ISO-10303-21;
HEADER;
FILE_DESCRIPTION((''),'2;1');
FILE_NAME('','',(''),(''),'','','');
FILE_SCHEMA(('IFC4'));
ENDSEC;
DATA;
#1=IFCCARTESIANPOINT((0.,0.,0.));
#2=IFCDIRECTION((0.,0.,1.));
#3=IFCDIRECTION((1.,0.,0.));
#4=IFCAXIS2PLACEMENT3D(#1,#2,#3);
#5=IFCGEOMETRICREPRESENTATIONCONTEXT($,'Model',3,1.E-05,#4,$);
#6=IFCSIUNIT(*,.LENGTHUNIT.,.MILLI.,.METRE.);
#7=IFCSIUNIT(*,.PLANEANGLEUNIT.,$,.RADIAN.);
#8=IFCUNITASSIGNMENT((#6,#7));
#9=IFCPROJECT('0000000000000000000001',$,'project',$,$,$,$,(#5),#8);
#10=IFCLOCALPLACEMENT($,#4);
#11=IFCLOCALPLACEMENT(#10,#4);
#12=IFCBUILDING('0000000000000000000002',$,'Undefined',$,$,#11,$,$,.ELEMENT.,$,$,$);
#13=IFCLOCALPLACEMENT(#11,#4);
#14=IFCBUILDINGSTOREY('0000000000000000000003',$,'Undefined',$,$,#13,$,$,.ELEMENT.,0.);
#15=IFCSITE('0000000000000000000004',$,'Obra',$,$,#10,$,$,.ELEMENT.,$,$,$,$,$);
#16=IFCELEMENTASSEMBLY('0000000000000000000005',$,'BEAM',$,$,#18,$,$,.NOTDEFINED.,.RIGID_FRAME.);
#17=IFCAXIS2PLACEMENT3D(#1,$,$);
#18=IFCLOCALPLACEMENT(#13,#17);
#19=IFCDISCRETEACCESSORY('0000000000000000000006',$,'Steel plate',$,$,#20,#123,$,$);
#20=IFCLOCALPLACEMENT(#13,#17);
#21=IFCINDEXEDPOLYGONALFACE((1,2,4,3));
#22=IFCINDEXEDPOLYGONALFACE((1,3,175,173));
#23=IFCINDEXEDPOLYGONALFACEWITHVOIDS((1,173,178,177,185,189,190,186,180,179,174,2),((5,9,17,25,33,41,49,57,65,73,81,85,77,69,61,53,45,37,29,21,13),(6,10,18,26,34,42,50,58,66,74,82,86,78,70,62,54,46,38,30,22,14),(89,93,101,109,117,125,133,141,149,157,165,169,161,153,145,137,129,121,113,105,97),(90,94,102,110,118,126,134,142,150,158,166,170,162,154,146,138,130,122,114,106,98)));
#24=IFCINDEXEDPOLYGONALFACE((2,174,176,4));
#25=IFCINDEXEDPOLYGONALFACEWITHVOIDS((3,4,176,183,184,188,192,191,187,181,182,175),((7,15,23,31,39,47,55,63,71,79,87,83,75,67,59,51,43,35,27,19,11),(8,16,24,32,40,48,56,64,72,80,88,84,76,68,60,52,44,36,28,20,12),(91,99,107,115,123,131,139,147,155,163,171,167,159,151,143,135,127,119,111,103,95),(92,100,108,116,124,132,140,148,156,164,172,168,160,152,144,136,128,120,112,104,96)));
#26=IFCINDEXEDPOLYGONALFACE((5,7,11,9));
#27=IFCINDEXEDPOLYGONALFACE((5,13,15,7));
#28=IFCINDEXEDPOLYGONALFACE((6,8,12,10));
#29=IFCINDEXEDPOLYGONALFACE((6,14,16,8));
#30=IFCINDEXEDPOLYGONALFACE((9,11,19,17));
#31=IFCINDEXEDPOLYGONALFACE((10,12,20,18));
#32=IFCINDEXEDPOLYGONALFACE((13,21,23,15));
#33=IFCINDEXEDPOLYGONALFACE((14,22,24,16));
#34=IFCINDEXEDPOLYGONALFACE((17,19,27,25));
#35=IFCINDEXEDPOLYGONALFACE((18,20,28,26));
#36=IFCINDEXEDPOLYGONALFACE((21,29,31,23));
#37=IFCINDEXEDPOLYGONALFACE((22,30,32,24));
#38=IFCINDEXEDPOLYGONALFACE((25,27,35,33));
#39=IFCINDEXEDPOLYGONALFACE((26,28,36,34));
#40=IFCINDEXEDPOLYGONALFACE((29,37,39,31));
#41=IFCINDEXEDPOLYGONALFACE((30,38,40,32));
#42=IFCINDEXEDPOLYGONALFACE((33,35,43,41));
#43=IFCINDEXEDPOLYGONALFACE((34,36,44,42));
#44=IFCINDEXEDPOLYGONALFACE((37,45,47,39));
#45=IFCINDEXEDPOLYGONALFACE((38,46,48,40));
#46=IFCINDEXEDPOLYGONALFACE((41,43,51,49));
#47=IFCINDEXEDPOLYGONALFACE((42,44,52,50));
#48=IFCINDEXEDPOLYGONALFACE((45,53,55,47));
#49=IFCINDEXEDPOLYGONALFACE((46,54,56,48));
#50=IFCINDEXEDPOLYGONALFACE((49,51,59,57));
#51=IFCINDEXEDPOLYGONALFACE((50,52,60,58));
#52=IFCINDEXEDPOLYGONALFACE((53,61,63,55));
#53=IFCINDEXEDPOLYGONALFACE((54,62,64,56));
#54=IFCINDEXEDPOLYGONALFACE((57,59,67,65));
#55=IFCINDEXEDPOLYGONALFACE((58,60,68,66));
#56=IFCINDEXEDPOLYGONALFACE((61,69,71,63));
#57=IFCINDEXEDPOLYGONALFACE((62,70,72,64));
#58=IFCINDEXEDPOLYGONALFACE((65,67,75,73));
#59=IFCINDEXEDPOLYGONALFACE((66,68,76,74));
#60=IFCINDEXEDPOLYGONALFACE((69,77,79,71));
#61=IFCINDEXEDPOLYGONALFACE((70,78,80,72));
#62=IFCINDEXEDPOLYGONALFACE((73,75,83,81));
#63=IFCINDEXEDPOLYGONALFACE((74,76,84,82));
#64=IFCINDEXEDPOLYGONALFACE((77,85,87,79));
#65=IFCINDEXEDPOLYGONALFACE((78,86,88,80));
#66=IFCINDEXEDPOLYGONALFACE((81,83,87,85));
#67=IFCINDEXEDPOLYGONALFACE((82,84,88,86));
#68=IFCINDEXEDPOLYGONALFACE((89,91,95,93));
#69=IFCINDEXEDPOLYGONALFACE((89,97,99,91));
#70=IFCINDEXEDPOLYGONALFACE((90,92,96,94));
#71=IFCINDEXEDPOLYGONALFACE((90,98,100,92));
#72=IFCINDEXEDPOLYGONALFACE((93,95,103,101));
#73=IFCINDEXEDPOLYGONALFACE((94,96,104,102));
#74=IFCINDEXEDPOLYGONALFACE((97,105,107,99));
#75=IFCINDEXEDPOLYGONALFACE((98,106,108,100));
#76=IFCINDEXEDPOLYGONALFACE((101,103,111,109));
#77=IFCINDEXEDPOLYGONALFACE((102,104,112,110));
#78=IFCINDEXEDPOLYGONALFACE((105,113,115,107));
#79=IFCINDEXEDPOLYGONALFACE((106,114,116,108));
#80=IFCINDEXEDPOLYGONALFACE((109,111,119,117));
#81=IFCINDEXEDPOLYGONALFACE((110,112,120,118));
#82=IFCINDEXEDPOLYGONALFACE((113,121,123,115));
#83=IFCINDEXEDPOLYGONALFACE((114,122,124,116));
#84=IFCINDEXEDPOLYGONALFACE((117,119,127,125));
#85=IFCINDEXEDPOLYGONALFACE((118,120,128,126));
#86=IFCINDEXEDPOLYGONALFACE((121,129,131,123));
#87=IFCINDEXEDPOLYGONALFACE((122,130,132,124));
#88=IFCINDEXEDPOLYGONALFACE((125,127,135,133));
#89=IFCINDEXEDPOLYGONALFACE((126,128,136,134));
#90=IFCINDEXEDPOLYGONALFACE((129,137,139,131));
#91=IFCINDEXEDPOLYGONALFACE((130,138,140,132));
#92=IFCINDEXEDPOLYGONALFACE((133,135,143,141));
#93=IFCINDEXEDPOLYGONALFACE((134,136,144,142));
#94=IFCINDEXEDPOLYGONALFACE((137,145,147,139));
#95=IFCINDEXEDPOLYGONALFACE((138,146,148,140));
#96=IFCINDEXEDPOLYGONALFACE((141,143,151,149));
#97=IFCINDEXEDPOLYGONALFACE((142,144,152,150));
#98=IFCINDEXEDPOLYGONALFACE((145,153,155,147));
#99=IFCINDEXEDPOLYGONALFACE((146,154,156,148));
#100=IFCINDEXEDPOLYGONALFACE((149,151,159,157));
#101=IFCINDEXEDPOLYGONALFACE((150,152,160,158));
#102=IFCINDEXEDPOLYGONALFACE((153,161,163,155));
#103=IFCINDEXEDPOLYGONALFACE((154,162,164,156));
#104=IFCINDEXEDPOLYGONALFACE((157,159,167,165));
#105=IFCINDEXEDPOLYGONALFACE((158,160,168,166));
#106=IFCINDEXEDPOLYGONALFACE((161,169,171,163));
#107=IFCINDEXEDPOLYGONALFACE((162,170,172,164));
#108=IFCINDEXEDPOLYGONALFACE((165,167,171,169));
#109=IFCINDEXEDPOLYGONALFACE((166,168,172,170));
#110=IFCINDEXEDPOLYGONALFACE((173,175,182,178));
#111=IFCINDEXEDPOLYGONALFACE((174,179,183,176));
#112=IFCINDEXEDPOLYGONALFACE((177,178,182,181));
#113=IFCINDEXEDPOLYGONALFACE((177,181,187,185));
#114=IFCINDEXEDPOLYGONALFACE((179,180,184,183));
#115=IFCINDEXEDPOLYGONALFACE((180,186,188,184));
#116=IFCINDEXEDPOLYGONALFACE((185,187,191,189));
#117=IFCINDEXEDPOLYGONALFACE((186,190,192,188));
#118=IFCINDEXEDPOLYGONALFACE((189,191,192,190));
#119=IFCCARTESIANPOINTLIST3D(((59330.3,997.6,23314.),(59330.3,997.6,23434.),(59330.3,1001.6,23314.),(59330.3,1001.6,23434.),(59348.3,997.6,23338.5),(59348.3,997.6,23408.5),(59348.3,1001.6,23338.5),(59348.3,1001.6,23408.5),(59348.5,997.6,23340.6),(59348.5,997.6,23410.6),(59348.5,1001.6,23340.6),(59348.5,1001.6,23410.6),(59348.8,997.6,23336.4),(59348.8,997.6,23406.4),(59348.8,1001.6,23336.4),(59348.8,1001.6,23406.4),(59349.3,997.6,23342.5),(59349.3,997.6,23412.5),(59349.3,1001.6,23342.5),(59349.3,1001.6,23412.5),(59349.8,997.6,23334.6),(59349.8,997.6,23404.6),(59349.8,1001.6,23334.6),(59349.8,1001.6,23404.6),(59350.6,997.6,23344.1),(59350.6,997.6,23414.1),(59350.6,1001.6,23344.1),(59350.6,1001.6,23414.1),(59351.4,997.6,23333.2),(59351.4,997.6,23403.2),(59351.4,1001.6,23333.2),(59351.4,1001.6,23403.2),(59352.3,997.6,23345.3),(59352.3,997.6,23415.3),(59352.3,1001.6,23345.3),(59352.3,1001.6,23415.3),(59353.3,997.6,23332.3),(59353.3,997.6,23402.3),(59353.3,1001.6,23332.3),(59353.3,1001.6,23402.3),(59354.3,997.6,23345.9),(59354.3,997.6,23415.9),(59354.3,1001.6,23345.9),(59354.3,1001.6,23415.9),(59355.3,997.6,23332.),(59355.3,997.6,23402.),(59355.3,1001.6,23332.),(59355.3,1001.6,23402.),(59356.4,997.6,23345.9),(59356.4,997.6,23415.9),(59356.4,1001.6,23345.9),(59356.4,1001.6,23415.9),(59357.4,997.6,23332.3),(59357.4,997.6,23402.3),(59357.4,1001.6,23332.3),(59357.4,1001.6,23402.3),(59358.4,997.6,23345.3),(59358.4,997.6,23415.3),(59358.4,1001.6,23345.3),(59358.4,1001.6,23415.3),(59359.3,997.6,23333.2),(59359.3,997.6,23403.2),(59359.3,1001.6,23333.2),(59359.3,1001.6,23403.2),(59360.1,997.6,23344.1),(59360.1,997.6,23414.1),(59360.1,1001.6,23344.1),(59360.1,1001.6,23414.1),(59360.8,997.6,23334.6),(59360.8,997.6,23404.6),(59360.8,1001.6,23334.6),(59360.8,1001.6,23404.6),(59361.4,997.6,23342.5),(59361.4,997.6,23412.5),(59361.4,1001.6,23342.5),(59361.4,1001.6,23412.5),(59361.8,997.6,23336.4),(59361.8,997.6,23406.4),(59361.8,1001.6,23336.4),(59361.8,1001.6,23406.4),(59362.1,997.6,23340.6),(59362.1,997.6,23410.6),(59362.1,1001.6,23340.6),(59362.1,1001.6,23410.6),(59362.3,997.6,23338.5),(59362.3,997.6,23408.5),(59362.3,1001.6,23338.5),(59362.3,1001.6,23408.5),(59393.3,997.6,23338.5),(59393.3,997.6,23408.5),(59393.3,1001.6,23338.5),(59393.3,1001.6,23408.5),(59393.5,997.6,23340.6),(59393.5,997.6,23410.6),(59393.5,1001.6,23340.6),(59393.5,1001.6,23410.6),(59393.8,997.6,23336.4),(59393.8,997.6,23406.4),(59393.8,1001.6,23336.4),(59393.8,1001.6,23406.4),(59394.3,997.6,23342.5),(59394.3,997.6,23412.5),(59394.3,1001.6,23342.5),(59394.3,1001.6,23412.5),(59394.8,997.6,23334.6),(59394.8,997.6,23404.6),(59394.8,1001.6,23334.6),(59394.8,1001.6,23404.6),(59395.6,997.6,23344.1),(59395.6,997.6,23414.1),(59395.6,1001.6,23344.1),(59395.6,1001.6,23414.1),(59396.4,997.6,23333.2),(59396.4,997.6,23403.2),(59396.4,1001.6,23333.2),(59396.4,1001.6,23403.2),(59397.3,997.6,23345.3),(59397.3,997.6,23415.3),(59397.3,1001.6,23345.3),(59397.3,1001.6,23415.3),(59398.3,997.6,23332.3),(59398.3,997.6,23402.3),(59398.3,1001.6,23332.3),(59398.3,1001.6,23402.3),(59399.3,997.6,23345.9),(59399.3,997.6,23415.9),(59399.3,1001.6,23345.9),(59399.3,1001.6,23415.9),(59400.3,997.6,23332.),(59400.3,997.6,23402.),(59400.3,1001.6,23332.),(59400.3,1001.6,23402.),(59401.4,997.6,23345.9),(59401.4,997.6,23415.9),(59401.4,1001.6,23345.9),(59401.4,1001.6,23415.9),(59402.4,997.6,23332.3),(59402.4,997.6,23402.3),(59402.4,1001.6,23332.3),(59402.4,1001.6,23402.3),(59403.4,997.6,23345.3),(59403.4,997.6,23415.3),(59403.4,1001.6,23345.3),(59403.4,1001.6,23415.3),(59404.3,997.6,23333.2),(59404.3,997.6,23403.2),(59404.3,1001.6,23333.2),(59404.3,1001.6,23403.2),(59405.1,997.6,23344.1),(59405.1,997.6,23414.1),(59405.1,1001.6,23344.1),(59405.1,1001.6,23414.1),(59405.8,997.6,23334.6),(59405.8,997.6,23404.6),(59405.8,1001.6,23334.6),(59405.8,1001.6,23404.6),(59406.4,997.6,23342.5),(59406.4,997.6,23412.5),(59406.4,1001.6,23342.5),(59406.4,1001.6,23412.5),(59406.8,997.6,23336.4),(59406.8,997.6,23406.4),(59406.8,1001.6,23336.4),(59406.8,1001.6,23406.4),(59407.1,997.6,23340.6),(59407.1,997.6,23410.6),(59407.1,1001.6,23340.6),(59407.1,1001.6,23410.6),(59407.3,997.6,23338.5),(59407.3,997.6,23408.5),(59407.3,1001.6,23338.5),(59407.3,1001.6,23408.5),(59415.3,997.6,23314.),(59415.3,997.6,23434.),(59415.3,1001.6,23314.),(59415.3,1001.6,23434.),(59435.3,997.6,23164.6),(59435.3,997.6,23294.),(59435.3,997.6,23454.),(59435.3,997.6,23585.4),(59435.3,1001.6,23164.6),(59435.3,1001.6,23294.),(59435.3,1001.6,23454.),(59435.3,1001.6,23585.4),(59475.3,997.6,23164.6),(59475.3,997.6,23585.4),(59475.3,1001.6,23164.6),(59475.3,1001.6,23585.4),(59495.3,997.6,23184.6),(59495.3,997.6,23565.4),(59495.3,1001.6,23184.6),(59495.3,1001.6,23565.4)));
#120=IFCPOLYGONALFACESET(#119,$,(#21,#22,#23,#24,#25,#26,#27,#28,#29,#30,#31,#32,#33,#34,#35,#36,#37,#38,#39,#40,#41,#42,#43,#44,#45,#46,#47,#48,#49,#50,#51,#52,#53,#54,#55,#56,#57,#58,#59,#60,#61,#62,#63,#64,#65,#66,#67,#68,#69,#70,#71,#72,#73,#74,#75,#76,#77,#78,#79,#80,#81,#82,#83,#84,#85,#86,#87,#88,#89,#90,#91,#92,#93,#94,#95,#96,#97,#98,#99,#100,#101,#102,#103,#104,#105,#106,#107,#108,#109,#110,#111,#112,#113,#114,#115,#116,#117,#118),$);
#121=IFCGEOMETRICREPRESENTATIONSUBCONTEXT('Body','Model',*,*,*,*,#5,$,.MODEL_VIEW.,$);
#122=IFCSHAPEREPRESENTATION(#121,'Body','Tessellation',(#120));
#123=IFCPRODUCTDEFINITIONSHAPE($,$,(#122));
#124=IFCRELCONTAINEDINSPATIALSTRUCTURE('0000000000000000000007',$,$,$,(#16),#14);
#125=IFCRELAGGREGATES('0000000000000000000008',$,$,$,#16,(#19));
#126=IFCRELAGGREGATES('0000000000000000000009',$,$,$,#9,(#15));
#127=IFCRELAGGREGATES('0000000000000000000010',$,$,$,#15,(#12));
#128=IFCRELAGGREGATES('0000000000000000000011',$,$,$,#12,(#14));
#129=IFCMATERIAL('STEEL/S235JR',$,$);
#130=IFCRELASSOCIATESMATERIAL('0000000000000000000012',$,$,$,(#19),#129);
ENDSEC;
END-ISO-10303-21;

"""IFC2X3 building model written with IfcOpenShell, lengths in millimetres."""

from ifc_helpers import new_model, si_unit, frame, origin_with_axes, origin_2d_with_axis, place, context, subcontext, project, spatial, polyline, circle, outline, extrude, source, transform, mapped, material, element, aggregate, save


model = new_model("IFC2X3")

# Units and contexts
model_context = context("Model", 3, precision=1e-05, world=origin_with_axes())
body_context = subcontext(model_context, "Body", "Model", "MODEL_VIEW")
ifc_project = project(units=[si_unit("LENGTHUNIT", "METRE", prefix="MILLI"), si_unit("PLANEANGLEUNIT", "RADIAN")], contexts=[model_context])

# Site, building, storey
site_placement = place(None, origin_with_axes())
site = spatial("IfcSite", under=ifc_project, at=site_placement, Name="Obra", CompositionType="ELEMENT")
building_placement = place(site_placement, origin_with_axes())
building = spatial("IfcBuilding", under=site, at=building_placement, Name="Undefined", CompositionType="ELEMENT")
storey_placement = place(building_placement, origin_with_axes())
storey = spatial("IfcBuildingStorey", under=building, at=storey_placement, Name="Undefined", CompositionType="ELEMENT", Elevation=0.0)

# Element assembly
assembly_1_placement = place(storey_placement, origin_with_axes())
assembly_1 = element("IfcElementAssembly", 1, at=assembly_1_placement, inside=storey, Name="BEAM", AssemblyPlace="NOTDEFINED", PredefinedType="RIGID_FRAME")
ifc_material_1 = material(Name="STEEL/S235JR")

# Discrete accessory, opening
discrete_accessory_1_placement = place(assembly_1_placement, frame((59495.3, 999.6, 23184.6), z_axis=(0.000014, 1.0, 0.0), x_axis=(-0.707107, 0.00001, -0.707107)))
discrete_accessory_1 = element("IfcDiscreteAccessory", 2, at=discrete_accessory_1_placement, material=ifc_material_1, Name="Steel plate", context=body_context, shape_type="SweptSolid", body=[
    extrude(outline(polyline([(0.0, 0.0), (28.3, 0.0), (56.6, 28.3), (-34.9, 119.8), (-34.9, 148.1), (25.2, 208.2), (-59.7, 293.0), (-119.8, 232.9), (-148.1, 232.9), (-241.0, 325.8), (-269.3, 297.6), (-269.3, 269.3), (0.0, 0.0)])), frame((0.0, 0.0, -2.0), z_axis=(0.0, 0.0, 1.0), x_axis=(1.0, 0.0, 0.0)), (0.0, 0.0, 1.0), 4.0),
])
shared_shape_1 = source(origin_with_axes(), body_context, "Body", "SweptSolid", [
    extrude(circle(Radius=7.0, at=origin_2d_with_axis()), frame((0.0, 32.4, 0.0), z_axis=(0.0, 1.0, 0.0), x_axis=(1.0, 0.0, 0.0)), (0.0, 0.0, 1.0), 4.2),
])
opening_1_placement = place(assembly_1_placement, frame((59425.3, 1034.1, 23434.0), z_axis=(-1.0, 0.000014, 0.0), x_axis=(0.0, 0.0, -1.0)))
element("IfcOpeningElement", 3, at=opening_1_placement, cuts=discrete_accessory_1, ObjectType="Opening", context=body_context, shape_type="MappedRepresentation", body=[
    mapped(shared_shape_1, transform((25.0, 0.0, 25.0))),
    mapped(shared_shape_1, transform((25.0, 0.0, 70.0))),
    mapped(shared_shape_1, transform((95.0, 0.0, 25.0))),
    mapped(shared_shape_1, transform((95.0, 0.0, 70.0))),
])
aggregate(assembly_1, [discrete_accessory_1])

save(model, "model.ifc")
